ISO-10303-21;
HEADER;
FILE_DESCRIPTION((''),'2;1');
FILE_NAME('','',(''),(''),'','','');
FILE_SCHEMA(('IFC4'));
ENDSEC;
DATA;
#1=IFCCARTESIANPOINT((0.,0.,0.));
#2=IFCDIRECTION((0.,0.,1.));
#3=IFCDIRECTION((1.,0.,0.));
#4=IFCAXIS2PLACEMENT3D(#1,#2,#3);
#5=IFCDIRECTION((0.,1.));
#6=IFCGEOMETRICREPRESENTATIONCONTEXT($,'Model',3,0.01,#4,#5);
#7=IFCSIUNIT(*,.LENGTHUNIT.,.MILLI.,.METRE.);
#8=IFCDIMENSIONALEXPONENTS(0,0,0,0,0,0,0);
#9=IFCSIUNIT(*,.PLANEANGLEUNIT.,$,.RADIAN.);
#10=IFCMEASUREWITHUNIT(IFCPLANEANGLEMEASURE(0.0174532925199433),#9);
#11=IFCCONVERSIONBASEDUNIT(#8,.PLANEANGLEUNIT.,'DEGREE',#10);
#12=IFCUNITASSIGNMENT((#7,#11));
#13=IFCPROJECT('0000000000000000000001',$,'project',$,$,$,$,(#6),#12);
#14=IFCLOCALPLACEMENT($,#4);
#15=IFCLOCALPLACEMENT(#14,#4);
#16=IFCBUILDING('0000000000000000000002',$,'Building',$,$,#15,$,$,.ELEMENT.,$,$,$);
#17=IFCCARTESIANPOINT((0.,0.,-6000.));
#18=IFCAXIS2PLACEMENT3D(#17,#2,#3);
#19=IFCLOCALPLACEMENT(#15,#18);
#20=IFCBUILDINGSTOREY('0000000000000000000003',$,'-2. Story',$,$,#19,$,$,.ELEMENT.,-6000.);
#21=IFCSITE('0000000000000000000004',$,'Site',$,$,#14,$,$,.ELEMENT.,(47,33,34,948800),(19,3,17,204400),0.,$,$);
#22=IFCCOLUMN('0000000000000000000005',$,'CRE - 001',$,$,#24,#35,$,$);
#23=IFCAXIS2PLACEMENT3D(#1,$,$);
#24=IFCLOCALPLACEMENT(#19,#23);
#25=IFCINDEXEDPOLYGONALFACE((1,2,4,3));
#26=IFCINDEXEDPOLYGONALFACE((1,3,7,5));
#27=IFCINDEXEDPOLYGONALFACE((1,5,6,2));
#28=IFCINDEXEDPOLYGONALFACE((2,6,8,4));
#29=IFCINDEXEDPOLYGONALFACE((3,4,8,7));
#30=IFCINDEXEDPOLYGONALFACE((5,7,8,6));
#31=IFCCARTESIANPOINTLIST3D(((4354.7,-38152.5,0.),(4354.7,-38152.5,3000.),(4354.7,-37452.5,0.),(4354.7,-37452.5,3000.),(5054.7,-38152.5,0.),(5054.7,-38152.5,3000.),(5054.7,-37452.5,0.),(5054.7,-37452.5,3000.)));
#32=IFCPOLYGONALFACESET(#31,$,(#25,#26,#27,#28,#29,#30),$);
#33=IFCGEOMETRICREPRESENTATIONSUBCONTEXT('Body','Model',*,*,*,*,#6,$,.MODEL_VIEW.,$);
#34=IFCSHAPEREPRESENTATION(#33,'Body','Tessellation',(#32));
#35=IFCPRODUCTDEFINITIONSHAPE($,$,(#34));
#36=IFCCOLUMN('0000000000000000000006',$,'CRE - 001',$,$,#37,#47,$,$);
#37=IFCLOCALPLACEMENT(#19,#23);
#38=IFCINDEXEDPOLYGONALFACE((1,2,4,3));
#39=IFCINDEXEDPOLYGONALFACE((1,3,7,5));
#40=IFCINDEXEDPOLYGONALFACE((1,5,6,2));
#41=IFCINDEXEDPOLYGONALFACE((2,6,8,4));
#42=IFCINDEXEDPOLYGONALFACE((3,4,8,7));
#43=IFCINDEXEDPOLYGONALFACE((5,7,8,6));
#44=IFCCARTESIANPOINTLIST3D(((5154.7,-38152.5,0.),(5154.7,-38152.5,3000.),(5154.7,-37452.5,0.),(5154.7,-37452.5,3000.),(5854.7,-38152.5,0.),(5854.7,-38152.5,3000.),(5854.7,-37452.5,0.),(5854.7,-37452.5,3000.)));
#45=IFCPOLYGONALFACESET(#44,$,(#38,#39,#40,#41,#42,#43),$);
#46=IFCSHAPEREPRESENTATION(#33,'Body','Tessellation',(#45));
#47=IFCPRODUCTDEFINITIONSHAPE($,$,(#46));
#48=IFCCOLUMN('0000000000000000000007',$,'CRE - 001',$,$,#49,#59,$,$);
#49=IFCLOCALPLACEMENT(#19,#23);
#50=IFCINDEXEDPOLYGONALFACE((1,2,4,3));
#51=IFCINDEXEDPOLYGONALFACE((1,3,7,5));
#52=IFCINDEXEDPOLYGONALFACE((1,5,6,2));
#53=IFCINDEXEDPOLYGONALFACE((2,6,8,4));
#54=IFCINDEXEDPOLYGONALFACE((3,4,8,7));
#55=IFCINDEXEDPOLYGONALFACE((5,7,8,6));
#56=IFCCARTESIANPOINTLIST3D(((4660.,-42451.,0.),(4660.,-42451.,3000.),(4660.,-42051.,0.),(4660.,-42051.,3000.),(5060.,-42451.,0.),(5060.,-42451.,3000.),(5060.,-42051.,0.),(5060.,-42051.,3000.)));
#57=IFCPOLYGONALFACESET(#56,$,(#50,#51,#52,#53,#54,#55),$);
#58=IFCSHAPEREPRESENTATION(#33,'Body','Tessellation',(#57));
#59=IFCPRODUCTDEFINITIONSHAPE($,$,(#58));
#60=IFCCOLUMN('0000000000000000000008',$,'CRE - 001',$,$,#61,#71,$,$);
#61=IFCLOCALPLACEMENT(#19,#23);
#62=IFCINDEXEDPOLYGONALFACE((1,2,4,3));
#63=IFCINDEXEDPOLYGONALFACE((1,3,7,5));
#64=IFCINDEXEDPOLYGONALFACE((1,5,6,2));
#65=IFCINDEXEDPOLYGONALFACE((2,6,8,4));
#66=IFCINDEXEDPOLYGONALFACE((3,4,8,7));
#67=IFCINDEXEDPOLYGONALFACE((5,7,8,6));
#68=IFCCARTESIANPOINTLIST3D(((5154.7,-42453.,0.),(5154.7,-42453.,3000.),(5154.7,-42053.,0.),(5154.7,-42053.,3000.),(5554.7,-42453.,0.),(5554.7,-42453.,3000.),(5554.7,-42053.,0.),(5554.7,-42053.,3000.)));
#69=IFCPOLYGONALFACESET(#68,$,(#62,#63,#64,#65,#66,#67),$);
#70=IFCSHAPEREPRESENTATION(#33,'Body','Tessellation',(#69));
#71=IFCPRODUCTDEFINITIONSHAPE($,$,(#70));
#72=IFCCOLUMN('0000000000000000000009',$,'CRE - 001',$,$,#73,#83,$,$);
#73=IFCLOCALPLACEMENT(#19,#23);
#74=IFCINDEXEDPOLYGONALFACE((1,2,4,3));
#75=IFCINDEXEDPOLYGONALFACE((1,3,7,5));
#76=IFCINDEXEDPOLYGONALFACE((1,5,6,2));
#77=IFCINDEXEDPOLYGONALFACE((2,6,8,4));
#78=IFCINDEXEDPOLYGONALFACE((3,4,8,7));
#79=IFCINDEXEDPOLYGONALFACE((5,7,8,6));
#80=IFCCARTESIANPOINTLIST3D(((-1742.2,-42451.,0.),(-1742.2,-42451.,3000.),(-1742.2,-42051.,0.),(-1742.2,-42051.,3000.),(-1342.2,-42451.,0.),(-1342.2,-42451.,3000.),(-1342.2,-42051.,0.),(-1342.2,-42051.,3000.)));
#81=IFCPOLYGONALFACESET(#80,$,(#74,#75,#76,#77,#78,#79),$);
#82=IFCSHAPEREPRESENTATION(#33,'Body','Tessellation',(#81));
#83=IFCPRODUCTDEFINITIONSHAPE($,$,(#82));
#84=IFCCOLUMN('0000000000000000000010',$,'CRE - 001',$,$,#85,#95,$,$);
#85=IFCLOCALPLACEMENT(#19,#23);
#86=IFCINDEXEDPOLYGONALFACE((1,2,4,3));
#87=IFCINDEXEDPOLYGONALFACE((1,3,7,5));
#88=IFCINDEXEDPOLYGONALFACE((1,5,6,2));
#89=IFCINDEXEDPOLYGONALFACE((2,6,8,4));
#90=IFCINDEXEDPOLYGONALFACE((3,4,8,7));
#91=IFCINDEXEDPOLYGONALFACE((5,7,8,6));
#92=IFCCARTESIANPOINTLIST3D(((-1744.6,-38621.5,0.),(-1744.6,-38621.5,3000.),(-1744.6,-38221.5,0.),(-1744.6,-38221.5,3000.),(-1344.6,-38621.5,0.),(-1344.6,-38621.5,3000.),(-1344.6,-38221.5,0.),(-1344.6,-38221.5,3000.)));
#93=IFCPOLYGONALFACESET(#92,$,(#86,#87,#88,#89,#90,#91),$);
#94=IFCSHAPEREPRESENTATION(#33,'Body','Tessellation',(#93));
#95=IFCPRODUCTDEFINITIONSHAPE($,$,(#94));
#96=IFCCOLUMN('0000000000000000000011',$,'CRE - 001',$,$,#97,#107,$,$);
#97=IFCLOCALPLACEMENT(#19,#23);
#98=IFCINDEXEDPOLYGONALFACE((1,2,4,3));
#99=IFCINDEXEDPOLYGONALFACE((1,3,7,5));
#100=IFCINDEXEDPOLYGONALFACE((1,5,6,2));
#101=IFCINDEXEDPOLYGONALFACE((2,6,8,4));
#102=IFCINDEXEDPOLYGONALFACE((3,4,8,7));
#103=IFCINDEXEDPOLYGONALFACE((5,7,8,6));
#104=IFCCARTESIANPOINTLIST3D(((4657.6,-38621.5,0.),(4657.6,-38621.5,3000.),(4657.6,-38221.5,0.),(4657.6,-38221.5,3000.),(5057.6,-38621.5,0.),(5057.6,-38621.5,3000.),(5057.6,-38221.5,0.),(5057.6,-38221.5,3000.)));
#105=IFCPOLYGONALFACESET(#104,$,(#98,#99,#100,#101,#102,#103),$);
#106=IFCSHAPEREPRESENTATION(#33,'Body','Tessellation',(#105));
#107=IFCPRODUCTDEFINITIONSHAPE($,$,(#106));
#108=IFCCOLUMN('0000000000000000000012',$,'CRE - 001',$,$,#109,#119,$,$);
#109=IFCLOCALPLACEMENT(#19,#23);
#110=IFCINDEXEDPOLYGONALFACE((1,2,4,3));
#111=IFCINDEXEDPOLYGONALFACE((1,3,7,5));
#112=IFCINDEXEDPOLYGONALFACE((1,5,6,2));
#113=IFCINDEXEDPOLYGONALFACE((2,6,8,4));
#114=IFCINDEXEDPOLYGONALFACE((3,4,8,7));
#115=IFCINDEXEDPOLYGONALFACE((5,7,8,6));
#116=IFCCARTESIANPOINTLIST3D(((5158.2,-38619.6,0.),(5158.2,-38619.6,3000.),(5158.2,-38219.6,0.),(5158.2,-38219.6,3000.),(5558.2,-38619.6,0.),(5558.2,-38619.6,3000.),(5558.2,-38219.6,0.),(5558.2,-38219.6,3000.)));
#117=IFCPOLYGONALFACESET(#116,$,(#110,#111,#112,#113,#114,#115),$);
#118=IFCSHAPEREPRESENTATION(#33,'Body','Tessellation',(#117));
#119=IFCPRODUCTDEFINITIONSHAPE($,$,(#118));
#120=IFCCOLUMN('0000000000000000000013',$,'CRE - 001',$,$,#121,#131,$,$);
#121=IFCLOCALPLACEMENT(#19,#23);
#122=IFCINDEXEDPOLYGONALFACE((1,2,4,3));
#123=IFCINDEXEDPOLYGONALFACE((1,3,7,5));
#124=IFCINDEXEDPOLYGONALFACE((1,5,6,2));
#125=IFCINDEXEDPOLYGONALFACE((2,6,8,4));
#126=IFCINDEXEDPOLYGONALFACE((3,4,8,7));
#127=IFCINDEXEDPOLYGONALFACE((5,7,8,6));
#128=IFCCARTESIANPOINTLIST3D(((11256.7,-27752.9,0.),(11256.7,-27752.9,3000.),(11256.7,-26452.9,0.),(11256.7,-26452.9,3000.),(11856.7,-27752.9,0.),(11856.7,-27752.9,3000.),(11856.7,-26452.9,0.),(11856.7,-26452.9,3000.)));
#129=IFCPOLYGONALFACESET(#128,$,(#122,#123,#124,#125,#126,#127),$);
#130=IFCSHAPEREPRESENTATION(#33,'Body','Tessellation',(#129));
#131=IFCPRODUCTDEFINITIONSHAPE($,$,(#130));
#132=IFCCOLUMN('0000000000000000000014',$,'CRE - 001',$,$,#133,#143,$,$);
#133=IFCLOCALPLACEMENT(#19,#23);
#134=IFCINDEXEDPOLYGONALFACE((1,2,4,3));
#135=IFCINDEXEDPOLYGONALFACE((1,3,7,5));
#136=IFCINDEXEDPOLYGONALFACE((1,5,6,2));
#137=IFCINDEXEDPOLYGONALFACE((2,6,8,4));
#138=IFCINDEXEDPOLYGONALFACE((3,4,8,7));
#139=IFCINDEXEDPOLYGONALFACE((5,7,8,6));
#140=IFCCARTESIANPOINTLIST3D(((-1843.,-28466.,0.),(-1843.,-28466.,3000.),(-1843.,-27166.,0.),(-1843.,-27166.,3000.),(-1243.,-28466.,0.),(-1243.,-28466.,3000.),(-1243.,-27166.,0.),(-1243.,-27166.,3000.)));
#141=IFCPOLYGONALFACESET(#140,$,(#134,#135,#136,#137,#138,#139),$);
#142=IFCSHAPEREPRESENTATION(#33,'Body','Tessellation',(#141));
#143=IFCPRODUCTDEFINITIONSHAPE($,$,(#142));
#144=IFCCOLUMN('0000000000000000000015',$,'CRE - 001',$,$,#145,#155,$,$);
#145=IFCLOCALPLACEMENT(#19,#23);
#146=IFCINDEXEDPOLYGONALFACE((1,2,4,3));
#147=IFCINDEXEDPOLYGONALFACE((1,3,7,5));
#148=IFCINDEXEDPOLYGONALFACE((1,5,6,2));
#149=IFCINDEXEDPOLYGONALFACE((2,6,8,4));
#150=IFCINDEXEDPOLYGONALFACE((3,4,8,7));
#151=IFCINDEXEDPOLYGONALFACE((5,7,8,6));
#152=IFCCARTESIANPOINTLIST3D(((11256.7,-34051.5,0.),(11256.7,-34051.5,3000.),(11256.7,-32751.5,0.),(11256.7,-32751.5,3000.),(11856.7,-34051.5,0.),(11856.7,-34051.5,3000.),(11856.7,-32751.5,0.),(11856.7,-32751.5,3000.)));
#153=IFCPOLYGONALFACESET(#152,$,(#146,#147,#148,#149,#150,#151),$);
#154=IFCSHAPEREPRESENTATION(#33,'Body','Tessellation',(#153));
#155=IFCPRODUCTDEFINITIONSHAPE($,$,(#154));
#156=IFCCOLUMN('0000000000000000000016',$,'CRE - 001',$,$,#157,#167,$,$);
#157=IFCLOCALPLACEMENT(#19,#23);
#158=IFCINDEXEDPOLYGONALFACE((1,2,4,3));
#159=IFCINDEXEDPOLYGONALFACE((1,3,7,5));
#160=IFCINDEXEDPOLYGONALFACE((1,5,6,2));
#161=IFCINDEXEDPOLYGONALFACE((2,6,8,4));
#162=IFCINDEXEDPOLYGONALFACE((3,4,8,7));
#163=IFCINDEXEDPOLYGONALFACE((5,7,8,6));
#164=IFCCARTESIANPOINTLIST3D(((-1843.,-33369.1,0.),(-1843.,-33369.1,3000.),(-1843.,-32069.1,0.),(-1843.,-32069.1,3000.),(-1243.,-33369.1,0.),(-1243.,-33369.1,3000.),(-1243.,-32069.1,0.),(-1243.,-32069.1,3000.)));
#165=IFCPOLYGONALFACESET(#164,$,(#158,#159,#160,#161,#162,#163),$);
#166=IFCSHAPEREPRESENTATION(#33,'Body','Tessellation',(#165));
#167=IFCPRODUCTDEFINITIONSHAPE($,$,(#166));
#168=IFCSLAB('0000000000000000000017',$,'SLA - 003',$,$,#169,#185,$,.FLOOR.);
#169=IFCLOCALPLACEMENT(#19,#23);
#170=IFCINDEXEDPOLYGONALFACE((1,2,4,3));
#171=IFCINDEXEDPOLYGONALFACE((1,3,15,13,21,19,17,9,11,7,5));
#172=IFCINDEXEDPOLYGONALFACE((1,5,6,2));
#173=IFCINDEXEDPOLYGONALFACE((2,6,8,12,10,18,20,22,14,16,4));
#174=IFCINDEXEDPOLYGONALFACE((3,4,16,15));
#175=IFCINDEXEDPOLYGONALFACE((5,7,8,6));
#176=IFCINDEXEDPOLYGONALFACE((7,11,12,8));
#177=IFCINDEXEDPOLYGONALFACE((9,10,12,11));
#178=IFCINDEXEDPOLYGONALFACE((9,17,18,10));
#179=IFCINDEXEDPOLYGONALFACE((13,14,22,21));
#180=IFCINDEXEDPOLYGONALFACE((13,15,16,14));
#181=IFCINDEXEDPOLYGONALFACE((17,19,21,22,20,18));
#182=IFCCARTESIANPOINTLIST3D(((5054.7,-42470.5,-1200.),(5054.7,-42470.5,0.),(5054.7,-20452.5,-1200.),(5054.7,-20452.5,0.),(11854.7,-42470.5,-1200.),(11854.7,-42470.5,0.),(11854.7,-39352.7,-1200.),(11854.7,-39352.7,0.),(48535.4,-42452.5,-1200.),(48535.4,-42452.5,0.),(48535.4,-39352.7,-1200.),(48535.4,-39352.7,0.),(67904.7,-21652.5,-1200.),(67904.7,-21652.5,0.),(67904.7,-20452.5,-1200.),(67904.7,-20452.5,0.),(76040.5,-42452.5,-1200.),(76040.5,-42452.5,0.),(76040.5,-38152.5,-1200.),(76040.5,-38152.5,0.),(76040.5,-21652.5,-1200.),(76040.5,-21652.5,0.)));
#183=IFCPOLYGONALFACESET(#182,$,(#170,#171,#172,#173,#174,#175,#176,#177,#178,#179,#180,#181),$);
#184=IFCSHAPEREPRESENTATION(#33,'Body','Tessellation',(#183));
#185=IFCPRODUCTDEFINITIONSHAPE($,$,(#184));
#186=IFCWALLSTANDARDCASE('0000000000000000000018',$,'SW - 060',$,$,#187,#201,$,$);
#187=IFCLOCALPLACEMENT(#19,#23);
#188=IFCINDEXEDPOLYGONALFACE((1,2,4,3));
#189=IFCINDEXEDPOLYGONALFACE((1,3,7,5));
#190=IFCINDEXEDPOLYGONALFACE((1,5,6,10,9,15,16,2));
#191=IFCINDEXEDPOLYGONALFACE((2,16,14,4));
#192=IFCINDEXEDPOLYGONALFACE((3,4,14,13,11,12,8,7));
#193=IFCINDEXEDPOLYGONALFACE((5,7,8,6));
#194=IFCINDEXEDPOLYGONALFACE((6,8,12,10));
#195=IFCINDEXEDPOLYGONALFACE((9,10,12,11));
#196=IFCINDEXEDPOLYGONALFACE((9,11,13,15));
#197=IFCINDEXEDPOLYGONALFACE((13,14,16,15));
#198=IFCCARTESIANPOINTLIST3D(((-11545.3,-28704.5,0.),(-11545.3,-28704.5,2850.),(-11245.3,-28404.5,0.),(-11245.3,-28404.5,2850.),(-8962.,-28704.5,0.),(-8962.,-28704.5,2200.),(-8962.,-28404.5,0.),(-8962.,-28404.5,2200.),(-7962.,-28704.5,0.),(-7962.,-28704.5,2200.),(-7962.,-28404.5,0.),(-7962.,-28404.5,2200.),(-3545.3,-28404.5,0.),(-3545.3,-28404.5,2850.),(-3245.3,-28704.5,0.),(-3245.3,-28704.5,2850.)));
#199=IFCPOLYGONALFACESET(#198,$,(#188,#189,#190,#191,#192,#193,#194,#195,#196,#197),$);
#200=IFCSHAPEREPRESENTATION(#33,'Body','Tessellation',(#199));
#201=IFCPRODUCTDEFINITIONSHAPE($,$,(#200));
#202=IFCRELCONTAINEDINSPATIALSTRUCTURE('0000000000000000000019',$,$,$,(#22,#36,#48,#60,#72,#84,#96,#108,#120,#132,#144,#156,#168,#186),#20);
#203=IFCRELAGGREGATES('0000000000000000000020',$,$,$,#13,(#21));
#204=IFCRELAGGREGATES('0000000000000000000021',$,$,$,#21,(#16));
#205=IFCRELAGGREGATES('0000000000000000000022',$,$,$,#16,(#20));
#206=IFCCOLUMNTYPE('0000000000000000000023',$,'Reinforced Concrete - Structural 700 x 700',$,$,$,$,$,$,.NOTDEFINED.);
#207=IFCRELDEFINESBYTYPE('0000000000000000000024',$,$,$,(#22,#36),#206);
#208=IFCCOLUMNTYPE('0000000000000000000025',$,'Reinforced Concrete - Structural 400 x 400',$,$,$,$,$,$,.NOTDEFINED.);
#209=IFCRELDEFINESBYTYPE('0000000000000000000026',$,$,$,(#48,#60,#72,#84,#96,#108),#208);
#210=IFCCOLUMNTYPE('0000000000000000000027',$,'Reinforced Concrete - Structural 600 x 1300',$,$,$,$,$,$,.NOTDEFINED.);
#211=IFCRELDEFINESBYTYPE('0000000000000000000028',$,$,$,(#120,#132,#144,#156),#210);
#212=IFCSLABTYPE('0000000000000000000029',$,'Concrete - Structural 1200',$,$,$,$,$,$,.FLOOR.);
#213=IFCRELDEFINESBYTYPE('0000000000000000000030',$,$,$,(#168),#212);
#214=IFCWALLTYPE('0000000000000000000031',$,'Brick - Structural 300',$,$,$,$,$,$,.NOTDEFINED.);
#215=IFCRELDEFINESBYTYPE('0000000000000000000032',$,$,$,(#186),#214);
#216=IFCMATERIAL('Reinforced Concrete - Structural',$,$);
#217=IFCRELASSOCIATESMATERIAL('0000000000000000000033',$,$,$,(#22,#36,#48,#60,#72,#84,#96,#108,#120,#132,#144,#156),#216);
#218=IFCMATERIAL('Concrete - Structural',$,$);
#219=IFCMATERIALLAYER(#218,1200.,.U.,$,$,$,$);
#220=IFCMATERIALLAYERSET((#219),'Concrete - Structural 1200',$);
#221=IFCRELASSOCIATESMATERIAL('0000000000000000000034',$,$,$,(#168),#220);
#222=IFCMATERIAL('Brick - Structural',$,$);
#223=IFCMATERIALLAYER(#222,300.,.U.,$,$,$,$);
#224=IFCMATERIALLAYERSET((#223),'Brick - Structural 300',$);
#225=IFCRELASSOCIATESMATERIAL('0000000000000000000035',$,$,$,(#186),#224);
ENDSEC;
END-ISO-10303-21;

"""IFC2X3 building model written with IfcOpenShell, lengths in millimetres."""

from ifc_helpers import new_model, entity, si_unit, converted_unit, direction, frame, origin_with_axes, origin_2d_with_axis, place, context, subcontext, project, spatial, polyline, rectangle, outline, extrude, material, layer, layer_set, layer_usage, type_object, element, save


model = new_model("IFC2X3")

# Units and contexts
model_context = context("Model", 3, precision=0.01, world=origin_with_axes(), true_north=direction((0.0, 1.0)))
body_context = subcontext(model_context, "Body", "Model", "MODEL_VIEW")
ifc_project = project(units=[si_unit("LENGTHUNIT", "METRE", prefix="MILLI"), converted_unit("PLANEANGLEUNIT", "DEGREE", entity("IfcPlaneAngleMeasure", 0.0174532925199433), si_unit("PLANEANGLEUNIT", "RADIAN"), dimensions=[0, 0, 0, 0, 0, 0, 0])], contexts=[model_context])

# Site, building, storey
site_placement = place(None, origin_with_axes())
site = spatial("IfcSite", under=ifc_project, at=site_placement, Name="Site", CompositionType="ELEMENT", RefLatitude=(47, 33, 34, 948800), RefLongitude=(19, 3, 17, 204400), RefElevation=0.0)
building_placement = place(site_placement, origin_with_axes())
building = spatial("IfcBuilding", under=site, at=building_placement, Name="Building", CompositionType="ELEMENT")
storey_placement = place(building_placement, frame((0.0, 0.0, -6000.0), z_axis=(0.0, 0.0, 1.0), x_axis=(1.0, 0.0, 0.0)))
storey = spatial("IfcBuildingStorey", under=building, at=storey_placement, Name="-2. Story", CompositionType="ELEMENT", Elevation=-6000.0)

# Columns
ifc_material_1 = material(Name="Reinforced Concrete - Structural")
column_type_1 = type_object("IfcColumnType", Name="Reinforced Concrete - Structural 700 x 700", PredefinedType="NOTDEFINED")
for number, where, z_axis, x_axis, name in (
    (1, (4704.7, -37802.5, 0.0), (0.0, 0.0, 1.0), (1.0, 0.0, 0.0), "CRE - 001"),
    (2, (5504.7, -37802.5, 0.0), (0.0, 0.0, 1.0), (1.0, 0.0, 0.0), "CRE - 001"),
):
    element("IfcColumn", number, at=place(storey_placement, frame(where, z_axis=z_axis, x_axis=x_axis)), inside=storey, type_object=column_type_1, material=ifc_material_1, Name=name, context=body_context, shape_type="SweptSolid", body=[
        extrude(rectangle(XDim=700.0, YDim=700.0, at=origin_2d_with_axis()), origin_with_axes(), (0.0, 0.0, 1.0), 3000.0),
    ])
column_type_2 = type_object("IfcColumnType", Name="Reinforced Concrete - Structural 400 x 400", PredefinedType="NOTDEFINED")
for number, where, z_axis, x_axis, name in (
    (3, (4860.0, -42251.0, 0.0), (0.0, 0.0, 1.0), (1.0, 0.0, 0.0), "CRE - 001"),
    (4, (5354.7, -42253.0, 0.0), (0.0, 0.0, 1.0), (1.0, 0.0, 0.0), "CRE - 001"),
    (5, (-1542.2, -42251.0, 0.0), (0.0, 0.0, 1.0), (1.0, 0.0, 0.0), "CRE - 001"),
    (6, (-1544.6, -38421.5, 0.0), (0.0, 0.0, 1.0), (1.0, 0.0, 0.0), "CRE - 001"),
    (7, (4857.6, -38421.5, 0.0), (0.0, 0.0, 1.0), (1.0, 0.0, 0.0), "CRE - 001"),
    (8, (5358.2, -38419.6, 0.0), (0.0, 0.0, 1.0), (1.0, 0.0, 0.0), "CRE - 001"),
):
    element("IfcColumn", number, at=place(storey_placement, frame(where, z_axis=z_axis, x_axis=x_axis)), inside=storey, type_object=column_type_2, material=ifc_material_1, Name=name, context=body_context, shape_type="SweptSolid", body=[
        extrude(rectangle(XDim=400.0, YDim=400.0, at=origin_2d_with_axis()), origin_with_axes(), (0.0, 0.0, 1.0), 3000.0),
    ])
column_type_3 = type_object("IfcColumnType", Name="Reinforced Concrete - Structural 600 x 1300", PredefinedType="NOTDEFINED")
for number, where, z_axis, x_axis, name in (
    (9, (11556.7, -27102.9, 0.0), (0.0, 0.0, 1.0), (1.0, 0.0, 0.0), "CRE - 001"),
    (10, (-1543.0, -27816.0, 0.0), (0.0, 0.0, 1.0), (1.0, 0.0, 0.0), "CRE - 001"),
    (11, (11556.7, -33401.5, 0.0), (0.0, 0.0, 1.0), (1.0, 0.0, 0.0), "CRE - 001"),
    (12, (-1543.0, -32719.1, 0.0), (0.0, 0.0, 1.0), (1.0, 0.0, 0.0), "CRE - 001"),
):
    element("IfcColumn", number, at=place(storey_placement, frame(where, z_axis=z_axis, x_axis=x_axis)), inside=storey, type_object=column_type_3, material=ifc_material_1, Name=name, context=body_context, shape_type="SweptSolid", body=[
        extrude(rectangle(XDim=600.0, YDim=1300.0, at=origin_2d_with_axis()), origin_with_axes(), (0.0, 0.0, 1.0), 3000.0),
    ])

# Slab
ifc_material_2 = material(Name="Concrete - Structural")
ifc_layer_1 = layer(ifc_material_2, 1200.0, ventilated="UNKNOWN")
ifc_layer_set_1 = layer_set([ifc_layer_1], Name="Concrete - Structural 1200")
ifc_layer_usage_1 = layer_usage(ifc_layer_set_1, "AXIS3", "NEGATIVE", 1200.0)
slab_type = type_object("IfcSlabType", Name="Concrete - Structural 1200", PredefinedType="FLOOR")
slab_placement = place(storey_placement, frame((5054.7, -42470.5, 0.0), z_axis=(0.0, 0.0, 1.0), x_axis=(1.0, 0.0, 0.0)))
element("IfcSlab", 13, at=slab_placement, inside=storey, type_object=slab_type, material=ifc_layer_usage_1, Name="SLA - 003", PredefinedType="FLOOR", context=body_context, shape_type="SweptSolid", body=[
    extrude(outline(polyline([(0.0, 0.0), (6800.0, 0.0), (6800.0, 3117.8), (43480.8, 3117.8), (43480.8, 17.9), (70985.8, 17.9), (70985.8, 4317.9), (70985.8, 20817.9), (62850.0, 20817.9), (62850.0, 22017.9), (0.0, 22017.9), (0.0, 0.0)])), frame((0.0, 0.0, -1200.0), z_axis=(0.0, 0.0, 1.0), x_axis=(1.0, 0.0, 0.0)), (0.0, 0.0, 1.0), 1200.0),
])

# Wall, opening
ifc_material_3 = material(Name="Brick - Structural")
ifc_layer_2 = layer(ifc_material_3, 300.0, ventilated="UNKNOWN")
ifc_layer_set_2 = layer_set([ifc_layer_2], Name="Brick - Structural 300")
ifc_layer_usage_2 = layer_usage(ifc_layer_set_2, "AXIS2", "NEGATIVE", 0.0)
wall_type_1 = type_object("IfcWallType", Name="Brick - Structural 300", PredefinedType="NOTDEFINED")
wall_1_placement = place(storey_placement, frame((-3245.3, -28704.5, 0.0), z_axis=(0.0, 0.0, 1.0), x_axis=(-1.0, 0.0, 0.0)))
wall_1 = element("IfcWallStandardCase", 14, at=wall_1_placement, inside=storey, type_object=wall_type_1, material=ifc_layer_usage_2, Name="SW - 060", context=body_context, shape_type="SweptSolid", body=[
    extrude(outline(polyline([(300.0, -300.0), (8000.0, -300.0), (8300.0, 0.0), (0.0, 0.0), (300.0, -300.0)])), origin_with_axes(), (0.0, 0.0, 1.0), 2850.0),
])
opening_1_placement = place(wall_1_placement, frame((5216.7, 0.0, 0.0), z_axis=(0.0, 0.0, 1.0), x_axis=(1.0, 0.0, 0.0)))
element("IfcOpeningElement", 15, at=opening_1_placement, cuts=wall_1, context=body_context, shape_type="SweptSolid", body=[
    extrude(rectangle(XDim=1000.0, YDim=2200.0, at=origin_2d_with_axis()), frame((0.0, -300.0, 1100.0), z_axis=(0.0, 1.0, 0.0), x_axis=(1.0, 0.0, 0.0)), (0.0, 0.0, -1.0), 300.0),
    extrude(rectangle(XDim=1000.0, YDim=2200.0, at=origin_2d_with_axis()), frame((0.0, -300.0, 1100.0), z_axis=(0.0, -1.0, 0.0), x_axis=(1.0, 0.0, 0.0)), (0.0, 0.0, -1.0), 300.0),
])

save(model, "model.ifc")
